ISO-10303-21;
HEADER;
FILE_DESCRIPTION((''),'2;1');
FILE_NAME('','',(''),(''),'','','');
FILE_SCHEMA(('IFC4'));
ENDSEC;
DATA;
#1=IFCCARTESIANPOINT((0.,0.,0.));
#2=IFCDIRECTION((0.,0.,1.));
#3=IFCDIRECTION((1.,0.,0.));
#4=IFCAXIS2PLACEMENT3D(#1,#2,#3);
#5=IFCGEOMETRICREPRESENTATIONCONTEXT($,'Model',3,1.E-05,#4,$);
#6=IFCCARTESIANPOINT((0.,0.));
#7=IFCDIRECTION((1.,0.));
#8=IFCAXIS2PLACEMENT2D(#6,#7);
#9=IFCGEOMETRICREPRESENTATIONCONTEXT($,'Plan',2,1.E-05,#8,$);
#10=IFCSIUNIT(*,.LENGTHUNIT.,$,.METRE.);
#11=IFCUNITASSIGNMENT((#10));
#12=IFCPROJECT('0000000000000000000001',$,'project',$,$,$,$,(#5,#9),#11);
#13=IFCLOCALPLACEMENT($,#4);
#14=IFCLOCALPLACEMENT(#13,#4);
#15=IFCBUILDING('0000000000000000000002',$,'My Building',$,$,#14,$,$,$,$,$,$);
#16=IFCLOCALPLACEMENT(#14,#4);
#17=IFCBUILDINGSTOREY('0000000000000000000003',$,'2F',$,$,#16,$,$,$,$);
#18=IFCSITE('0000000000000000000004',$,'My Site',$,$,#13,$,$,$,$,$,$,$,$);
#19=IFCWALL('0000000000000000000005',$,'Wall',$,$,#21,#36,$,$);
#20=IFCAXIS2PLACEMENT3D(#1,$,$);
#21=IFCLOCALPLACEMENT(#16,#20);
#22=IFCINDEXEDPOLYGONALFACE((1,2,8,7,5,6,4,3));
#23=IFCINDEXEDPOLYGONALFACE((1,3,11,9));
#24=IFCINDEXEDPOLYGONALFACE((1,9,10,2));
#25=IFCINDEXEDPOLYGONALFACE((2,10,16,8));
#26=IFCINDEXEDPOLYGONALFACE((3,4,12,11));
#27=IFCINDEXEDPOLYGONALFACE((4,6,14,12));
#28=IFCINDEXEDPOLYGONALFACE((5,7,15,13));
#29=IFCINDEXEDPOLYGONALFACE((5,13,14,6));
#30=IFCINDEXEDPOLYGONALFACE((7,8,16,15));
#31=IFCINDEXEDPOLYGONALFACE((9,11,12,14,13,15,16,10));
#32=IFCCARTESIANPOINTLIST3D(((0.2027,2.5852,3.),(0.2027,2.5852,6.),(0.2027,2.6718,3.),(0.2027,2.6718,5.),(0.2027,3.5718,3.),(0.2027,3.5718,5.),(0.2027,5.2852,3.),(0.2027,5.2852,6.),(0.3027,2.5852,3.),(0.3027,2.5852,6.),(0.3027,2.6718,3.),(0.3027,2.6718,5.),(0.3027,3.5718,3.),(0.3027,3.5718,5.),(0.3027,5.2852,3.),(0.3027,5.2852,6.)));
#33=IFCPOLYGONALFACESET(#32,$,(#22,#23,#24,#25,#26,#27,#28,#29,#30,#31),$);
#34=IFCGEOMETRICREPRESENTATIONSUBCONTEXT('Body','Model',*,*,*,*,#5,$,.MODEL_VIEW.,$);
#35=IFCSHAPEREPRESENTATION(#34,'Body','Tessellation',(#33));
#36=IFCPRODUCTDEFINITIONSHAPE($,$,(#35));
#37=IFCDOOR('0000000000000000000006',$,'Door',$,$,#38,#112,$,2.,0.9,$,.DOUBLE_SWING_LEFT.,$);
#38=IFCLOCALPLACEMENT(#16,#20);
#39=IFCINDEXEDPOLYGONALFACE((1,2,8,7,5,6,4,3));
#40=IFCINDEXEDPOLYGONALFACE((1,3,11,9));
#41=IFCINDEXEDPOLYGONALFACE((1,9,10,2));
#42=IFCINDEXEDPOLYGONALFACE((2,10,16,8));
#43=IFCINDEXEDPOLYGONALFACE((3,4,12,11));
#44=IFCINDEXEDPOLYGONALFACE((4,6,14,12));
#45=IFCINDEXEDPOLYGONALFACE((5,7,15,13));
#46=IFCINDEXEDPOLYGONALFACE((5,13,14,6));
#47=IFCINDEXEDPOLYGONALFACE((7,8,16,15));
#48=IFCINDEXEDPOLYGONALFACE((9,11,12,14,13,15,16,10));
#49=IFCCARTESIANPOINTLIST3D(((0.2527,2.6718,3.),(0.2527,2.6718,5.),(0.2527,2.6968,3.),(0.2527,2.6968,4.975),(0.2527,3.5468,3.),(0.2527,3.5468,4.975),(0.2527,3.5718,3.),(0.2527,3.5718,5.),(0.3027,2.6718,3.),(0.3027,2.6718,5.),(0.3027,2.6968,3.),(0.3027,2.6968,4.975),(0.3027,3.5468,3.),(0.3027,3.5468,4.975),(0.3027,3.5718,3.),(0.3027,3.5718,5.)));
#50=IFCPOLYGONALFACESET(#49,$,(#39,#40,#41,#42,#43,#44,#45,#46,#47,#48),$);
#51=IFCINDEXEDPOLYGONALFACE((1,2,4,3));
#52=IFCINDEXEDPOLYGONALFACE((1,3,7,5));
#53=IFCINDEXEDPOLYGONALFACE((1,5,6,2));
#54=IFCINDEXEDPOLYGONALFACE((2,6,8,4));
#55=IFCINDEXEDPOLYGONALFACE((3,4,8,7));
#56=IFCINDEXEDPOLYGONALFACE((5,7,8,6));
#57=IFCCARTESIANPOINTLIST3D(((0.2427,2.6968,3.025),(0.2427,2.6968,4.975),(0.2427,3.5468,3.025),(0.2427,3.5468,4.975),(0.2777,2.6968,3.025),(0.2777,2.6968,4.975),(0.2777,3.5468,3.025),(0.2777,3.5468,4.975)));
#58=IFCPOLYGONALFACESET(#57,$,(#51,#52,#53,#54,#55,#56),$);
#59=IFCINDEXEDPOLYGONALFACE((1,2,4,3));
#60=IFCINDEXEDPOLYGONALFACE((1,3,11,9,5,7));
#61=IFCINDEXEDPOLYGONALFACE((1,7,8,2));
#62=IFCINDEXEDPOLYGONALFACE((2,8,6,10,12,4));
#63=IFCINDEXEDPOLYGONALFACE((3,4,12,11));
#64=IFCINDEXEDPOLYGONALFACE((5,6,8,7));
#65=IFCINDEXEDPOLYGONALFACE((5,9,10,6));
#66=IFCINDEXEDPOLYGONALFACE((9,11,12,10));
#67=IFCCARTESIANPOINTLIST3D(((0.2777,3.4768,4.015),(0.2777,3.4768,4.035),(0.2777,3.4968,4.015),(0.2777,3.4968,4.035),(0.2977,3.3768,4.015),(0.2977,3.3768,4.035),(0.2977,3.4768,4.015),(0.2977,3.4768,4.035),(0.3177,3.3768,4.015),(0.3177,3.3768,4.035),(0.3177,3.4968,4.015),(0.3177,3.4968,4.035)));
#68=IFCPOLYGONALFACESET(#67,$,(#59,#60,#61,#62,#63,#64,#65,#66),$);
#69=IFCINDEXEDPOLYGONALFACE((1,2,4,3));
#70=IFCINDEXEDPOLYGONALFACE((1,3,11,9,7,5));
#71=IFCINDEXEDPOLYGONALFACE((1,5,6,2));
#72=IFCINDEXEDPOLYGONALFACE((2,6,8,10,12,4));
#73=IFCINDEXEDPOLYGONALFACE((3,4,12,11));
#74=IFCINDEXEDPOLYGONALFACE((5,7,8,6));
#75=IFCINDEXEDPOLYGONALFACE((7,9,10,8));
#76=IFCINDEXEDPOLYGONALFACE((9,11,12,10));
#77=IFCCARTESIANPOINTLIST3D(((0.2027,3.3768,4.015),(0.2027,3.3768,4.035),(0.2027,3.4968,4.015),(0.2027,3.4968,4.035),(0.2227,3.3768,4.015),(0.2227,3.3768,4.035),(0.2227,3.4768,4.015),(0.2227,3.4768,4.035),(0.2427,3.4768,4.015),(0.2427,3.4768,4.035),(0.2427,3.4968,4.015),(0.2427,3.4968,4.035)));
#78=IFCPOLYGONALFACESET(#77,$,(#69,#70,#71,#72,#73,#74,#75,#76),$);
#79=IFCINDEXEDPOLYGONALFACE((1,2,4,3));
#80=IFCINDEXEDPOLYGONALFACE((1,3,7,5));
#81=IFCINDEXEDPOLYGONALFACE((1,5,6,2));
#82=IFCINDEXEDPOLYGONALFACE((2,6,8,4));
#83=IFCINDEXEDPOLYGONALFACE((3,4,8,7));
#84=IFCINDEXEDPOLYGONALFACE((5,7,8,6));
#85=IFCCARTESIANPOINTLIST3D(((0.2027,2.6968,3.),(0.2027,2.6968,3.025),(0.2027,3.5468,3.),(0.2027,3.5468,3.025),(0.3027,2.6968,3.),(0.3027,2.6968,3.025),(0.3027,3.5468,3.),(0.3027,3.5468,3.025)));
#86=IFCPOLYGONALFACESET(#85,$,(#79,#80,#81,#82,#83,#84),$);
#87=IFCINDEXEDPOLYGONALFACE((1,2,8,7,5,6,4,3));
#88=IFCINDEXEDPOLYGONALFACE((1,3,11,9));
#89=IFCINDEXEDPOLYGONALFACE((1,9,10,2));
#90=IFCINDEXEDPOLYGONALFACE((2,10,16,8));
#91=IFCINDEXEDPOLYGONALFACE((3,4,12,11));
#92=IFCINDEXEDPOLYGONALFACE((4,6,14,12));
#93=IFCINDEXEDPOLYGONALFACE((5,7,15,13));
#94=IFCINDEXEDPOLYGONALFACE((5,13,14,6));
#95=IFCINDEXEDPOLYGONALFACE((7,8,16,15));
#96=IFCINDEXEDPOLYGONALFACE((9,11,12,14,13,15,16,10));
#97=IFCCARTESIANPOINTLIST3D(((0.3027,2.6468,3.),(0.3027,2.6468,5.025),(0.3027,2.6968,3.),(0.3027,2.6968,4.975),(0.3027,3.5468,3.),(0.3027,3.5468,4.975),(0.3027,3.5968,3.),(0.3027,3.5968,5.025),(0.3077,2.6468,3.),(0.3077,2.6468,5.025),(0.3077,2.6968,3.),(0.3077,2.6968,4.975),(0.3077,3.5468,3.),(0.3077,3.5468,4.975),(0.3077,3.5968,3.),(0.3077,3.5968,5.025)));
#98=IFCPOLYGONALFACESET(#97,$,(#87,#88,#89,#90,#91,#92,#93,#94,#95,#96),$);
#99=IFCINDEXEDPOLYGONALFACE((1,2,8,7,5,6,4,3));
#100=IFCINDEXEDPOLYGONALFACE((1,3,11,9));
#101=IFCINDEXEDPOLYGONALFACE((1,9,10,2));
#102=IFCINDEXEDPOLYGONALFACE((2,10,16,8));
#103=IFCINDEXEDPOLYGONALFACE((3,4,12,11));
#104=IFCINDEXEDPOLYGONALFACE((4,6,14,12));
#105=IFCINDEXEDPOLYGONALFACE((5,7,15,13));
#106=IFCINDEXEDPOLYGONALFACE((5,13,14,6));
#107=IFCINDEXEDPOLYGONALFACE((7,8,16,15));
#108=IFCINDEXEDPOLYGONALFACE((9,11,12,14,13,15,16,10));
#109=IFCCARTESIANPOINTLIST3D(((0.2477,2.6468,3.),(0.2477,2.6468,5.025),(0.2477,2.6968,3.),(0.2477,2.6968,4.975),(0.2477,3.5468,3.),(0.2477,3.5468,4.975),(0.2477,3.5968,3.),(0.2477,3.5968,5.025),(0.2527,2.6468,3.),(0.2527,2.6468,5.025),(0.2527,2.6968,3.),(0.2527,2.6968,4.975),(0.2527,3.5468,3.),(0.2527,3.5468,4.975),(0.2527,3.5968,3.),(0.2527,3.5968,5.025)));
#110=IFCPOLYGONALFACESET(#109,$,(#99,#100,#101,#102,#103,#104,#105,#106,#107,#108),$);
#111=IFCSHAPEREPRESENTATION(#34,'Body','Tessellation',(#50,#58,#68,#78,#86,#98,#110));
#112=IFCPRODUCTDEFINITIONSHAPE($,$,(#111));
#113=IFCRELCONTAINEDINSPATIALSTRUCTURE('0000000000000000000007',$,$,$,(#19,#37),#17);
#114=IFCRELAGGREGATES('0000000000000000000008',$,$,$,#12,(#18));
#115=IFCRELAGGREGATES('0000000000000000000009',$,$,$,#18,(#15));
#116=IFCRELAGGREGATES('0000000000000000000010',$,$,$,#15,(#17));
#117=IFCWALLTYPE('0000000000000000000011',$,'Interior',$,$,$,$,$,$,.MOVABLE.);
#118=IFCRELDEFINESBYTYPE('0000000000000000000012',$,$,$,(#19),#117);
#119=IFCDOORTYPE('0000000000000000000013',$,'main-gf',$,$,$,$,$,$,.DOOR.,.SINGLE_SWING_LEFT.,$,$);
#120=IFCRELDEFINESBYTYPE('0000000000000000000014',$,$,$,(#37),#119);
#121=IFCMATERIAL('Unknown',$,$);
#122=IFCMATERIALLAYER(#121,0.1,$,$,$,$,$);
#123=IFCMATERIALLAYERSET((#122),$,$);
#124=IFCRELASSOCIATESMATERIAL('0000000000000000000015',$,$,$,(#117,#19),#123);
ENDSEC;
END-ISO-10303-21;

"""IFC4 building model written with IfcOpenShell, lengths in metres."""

from ifc_helpers import new_model, entity, si_unit, frame, origin_with_axes, origin_2d_with_axis, place, context, subcontext, project, spatial, line, indexed_curve, outline, extrude, shape, source, transform, mapped, material, layer, layer_set, layer_usage, type_object, type_shapes, element, fill, save


model = new_model("IFC4")

# Units and contexts
model_context = context("Model", 3, precision=1e-05, world=origin_with_axes())
plan_context = context("Plan", 2, precision=1e-05, world=origin_2d_with_axis())
body_context_1 = subcontext(model_context, "Body", "Model", "MODEL_VIEW")
body_context_2 = subcontext(plan_context, "Body", "Plan", "PLAN_VIEW")
ifc_project = project(units=[si_unit("LENGTHUNIT", "METRE")], contexts=[model_context, plan_context])

# Site, building, storey
site_placement = place(None, origin_with_axes())
site = spatial("IfcSite", under=ifc_project, at=site_placement, Name="My Site")
building_placement = place(site_placement, origin_with_axes())
building = spatial("IfcBuilding", under=site, at=building_placement, Name="My Building")
storey_placement = place(building_placement, origin_with_axes())
storey = spatial("IfcBuildingStorey", under=building, at=storey_placement, Name="2F")

# Shared definitions
ifc_material = material(Name="Unknown")

# Shared definitions
ifc_layer_1 = layer(ifc_material, 0.1)
ifc_layer_set_1 = layer_set([ifc_layer_1])
wall_type = type_object("IfcWallType", Name="Interior", PredefinedType="MOVABLE", material=ifc_layer_set_1)

# Shared definitions
shared_shape_1 = source(origin_with_axes(), body_context_1, "Body", "SweptSolid", [
    extrude(outline(indexed_curve([(0.0, 0.0), (0.9, 0.0), (0.9, 2.0), (0.0, 2.0)], segments=[line(1, 2, 3, 4, 1)])), frame((0.0, -0.6, 0.0), z_axis=(0.0, -1.0, 0.0), x_axis=(1.0, 0.0, 0.0)), (0.0, 0.0, -1.0), 1.2),
])
door_type = type_object("IfcDoorType", Name="main-gf", OperationType="SINGLE_SWING_LEFT", PredefinedType="DOOR")
shared_shape_2 = source(origin_with_axes(), body_context_1, "Body", "SweptSolid", [
    extrude(outline(indexed_curve([(0.0, 0.0), (0.0, 2.0), (0.9, 2.0), (0.9, 0.0), (0.875, 0.0), (0.875, 1.975), (0.025, 1.975), (0.025, 0.0)], segments=[line(1, 2, 3, 4, 5, 6, 7, 8, 1)])), frame((0.0, 0.0, 0.0), z_axis=(0.0, -1.0, 0.0), x_axis=(1.0, 0.0, 0.0)), (0.0, 0.0, -1.0), 0.05),
    extrude(outline(indexed_curve([(0.0, 0.0), (0.85, 0.0), (0.85, 0.035), (0.0, 0.035)], segments=[line(1, 2, 3, 4, 1)])), frame((0.025, 0.025, 0.025), z_axis=(0.0, 0.0, 1.0), x_axis=(1.0, 0.0, 0.0)), (0.0, 0.0, 1.0), 1.95),
    extrude(outline(indexed_curve([(0.0, 0.0), (0.0, -0.04), (-0.12, -0.04), (-0.12, -0.02), (-0.02, -0.02), (-0.02, 0.0)], segments=[line(1, 2, 3, 4, 5, 6, 1)])), frame((0.825, 0.025, 1.015), z_axis=(0.0, 0.0, 1.0), x_axis=(1.0, 0.0, 0.0)), (0.0, 0.0, 1.0), 0.02),
    extrude(outline(indexed_curve([(0.0, 0.0), (0.0, 0.04), (-0.12, 0.04), (-0.12, 0.02), (-0.02, 0.02), (-0.02, 0.0)], segments=[line(1, 2, 3, 4, 5, 6, 1)])), frame((0.825, 0.06, 1.015), z_axis=(0.0, 0.0, 1.0), x_axis=(1.0, 0.0, 0.0)), (0.0, 0.0, 1.0), 0.02),
    extrude(outline(indexed_curve([(0.0, 0.0), (0.85, 0.0), (0.85, 0.1), (0.0, 0.1)], segments=[line(1, 2, 3, 4, 1)])), frame((0.025, 0.0, 0.0), z_axis=(0.0, 0.0, 1.0), x_axis=(1.0, 0.0, 0.0)), (0.0, 0.0, 1.0), 0.025),
    extrude(outline(indexed_curve([(0.0, 0.0), (0.0, 2.025), (0.95, 2.025), (0.95, 0.0), (0.9, 0.0), (0.9, 1.975), (0.05, 1.975), (0.05, 0.0)], segments=[line(1, 2, 3, 4, 5, 6, 7, 8, 1)])), frame((-0.025, -0.005, 0.0), z_axis=(0.0, -1.0, 0.0), x_axis=(1.0, 0.0, 0.0)), (0.0, 0.0, -1.0), 0.005),
    extrude(outline(indexed_curve([(0.0, 0.0), (0.0, 2.025), (0.95, 2.025), (0.95, 0.0), (0.9, 0.0), (0.9, 1.975), (0.05, 1.975), (0.05, 0.0)], segments=[line(1, 2, 3, 4, 5, 6, 7, 8, 1)])), frame((-0.025, 0.05, 0.0), z_axis=(0.0, -1.0, 0.0), x_axis=(1.0, 0.0, 0.0)), (0.0, 0.0, -1.0), 0.005),
])
shared_shape_3 = source(origin_with_axes(), body_context_2, "Body", "Curve2D", [
    entity("IfcIndexedPolyCurve", entity("IfcCartesianPointList2D", [[0.0, 0.0], [0.025, 0.0], [0.025, 0.05], [0.0, 0.05]]), [entity("IfcLineIndex", [1, 2, 3, 4, 1])]),
    entity("IfcIndexedPolyCurve", entity("IfcCartesianPointList2D", [[0.9, 0.0], [0.875, 0.0], [0.875, 0.05], [0.9, 0.05]]), [entity("IfcLineIndex", [1, 2, 3, 4, 1])]),
    entity("IfcIndexedPolyCurve", entity("IfcCartesianPointList2D", [[0.025, 0.05], [0.025, -0.8], [0.06, -0.8]])),
    entity("IfcTrimmedCurve", entity("IfcEllipse", entity("IfcAxis2Placement2D", entity("IfcCartesianPoint", [0.06, 0.05]), entity("IfcDirection", [1.0, 0.0])), 0.815, 0.85), [entity("IfcCartesianPoint", [0.06, -0.8])], [entity("IfcCartesianPoint", [0.06, 0.9])], True, "CARTESIAN"),
    entity("IfcIndexedPolyCurve", entity("IfcCartesianPointList2D", [[0.025, 0.05], [0.06, 0.05], [0.06, 0.9], [0.025, 0.9]]), [entity("IfcLineIndex", [1, 2, 3, 4, 1])]),
])
type_shapes(door_type, [shared_shape_2, shared_shape_3])

# Wall, opening, door
ifc_layer_usage_1 = layer_usage(ifc_layer_set_1, "AXIS2", "POSITIVE", 0.0)
wall_1_placement = place(storey_placement, frame((0.3027, 2.5852, 3.0), z_axis=(0.0, 0.0, 1.0), x_axis=(0.0, 1.0, 0.0)))
wall_1 = element("IfcWall", 1, at=wall_1_placement, inside=storey, type_object=wall_type, material=ifc_layer_usage_1, Name="Wall", context=body_context_1, shape_type="SweptSolid", body=[
    extrude(outline(indexed_curve([(0.0, 0.0), (0.0, 0.1), (2.7, 0.1), (2.7, 0.0)], segments=[line(1, 2, 3, 4, 1)])), origin_with_axes(), (0.0, 0.0, 1.0), 3.0),
])
opening_1_placement = place(wall_1_placement, frame((0.0866, 0.0, 0.0), z_axis=(0.0, 0.0, 1.0), x_axis=(1.0, 0.0, 0.0)))
opening_1 = element("IfcOpeningElement", 2, at=opening_1_placement, cuts=wall_1, PredefinedType="OPENING", context=body_context_1, shape_type="MappedRepresentation", body=[
    mapped(shared_shape_1, transform((0.0, 0.0, 0.0), x_axis=(1.0, 0.0, 0.0), y_axis=(0.0, 1.0, 0.0), z_axis=(0.0, 0.0, 1.0), scale=1.0)),
])
door_1_placement = place(opening_1_placement, frame((0.0, 0.0, 0.0), z_axis=(0.0, 0.0, 1.0), x_axis=(1.0, 0.0, 0.0)))
door_1 = element("IfcDoor", 3, at=door_1_placement, inside=storey, type_object=door_type, Name="Door", OperationType="DOUBLE_SWING_LEFT", OverallHeight=2.0, OverallWidth=0.9, shapes=[
    shape(body_context_1, "Body", "MappedRepresentation", [mapped(shared_shape_2, transform((0.0, 0.0, 0.0), x_axis=(1.0, 0.0, 0.0), y_axis=(0.0, 1.0, 0.0), z_axis=(0.0, 0.0, 1.0), scale=1.0))]),
    shape(body_context_2, "Body", "MappedRepresentation", [mapped(shared_shape_3, transform((0.0, 0.0, 0.0), x_axis=(1.0, 0.0, 0.0), y_axis=(0.0, 1.0, 0.0), z_axis=(0.0, 0.0, 1.0), scale=1.0))]),
])
fill(opening_1, door_1)

save(model, "model.ifc")
